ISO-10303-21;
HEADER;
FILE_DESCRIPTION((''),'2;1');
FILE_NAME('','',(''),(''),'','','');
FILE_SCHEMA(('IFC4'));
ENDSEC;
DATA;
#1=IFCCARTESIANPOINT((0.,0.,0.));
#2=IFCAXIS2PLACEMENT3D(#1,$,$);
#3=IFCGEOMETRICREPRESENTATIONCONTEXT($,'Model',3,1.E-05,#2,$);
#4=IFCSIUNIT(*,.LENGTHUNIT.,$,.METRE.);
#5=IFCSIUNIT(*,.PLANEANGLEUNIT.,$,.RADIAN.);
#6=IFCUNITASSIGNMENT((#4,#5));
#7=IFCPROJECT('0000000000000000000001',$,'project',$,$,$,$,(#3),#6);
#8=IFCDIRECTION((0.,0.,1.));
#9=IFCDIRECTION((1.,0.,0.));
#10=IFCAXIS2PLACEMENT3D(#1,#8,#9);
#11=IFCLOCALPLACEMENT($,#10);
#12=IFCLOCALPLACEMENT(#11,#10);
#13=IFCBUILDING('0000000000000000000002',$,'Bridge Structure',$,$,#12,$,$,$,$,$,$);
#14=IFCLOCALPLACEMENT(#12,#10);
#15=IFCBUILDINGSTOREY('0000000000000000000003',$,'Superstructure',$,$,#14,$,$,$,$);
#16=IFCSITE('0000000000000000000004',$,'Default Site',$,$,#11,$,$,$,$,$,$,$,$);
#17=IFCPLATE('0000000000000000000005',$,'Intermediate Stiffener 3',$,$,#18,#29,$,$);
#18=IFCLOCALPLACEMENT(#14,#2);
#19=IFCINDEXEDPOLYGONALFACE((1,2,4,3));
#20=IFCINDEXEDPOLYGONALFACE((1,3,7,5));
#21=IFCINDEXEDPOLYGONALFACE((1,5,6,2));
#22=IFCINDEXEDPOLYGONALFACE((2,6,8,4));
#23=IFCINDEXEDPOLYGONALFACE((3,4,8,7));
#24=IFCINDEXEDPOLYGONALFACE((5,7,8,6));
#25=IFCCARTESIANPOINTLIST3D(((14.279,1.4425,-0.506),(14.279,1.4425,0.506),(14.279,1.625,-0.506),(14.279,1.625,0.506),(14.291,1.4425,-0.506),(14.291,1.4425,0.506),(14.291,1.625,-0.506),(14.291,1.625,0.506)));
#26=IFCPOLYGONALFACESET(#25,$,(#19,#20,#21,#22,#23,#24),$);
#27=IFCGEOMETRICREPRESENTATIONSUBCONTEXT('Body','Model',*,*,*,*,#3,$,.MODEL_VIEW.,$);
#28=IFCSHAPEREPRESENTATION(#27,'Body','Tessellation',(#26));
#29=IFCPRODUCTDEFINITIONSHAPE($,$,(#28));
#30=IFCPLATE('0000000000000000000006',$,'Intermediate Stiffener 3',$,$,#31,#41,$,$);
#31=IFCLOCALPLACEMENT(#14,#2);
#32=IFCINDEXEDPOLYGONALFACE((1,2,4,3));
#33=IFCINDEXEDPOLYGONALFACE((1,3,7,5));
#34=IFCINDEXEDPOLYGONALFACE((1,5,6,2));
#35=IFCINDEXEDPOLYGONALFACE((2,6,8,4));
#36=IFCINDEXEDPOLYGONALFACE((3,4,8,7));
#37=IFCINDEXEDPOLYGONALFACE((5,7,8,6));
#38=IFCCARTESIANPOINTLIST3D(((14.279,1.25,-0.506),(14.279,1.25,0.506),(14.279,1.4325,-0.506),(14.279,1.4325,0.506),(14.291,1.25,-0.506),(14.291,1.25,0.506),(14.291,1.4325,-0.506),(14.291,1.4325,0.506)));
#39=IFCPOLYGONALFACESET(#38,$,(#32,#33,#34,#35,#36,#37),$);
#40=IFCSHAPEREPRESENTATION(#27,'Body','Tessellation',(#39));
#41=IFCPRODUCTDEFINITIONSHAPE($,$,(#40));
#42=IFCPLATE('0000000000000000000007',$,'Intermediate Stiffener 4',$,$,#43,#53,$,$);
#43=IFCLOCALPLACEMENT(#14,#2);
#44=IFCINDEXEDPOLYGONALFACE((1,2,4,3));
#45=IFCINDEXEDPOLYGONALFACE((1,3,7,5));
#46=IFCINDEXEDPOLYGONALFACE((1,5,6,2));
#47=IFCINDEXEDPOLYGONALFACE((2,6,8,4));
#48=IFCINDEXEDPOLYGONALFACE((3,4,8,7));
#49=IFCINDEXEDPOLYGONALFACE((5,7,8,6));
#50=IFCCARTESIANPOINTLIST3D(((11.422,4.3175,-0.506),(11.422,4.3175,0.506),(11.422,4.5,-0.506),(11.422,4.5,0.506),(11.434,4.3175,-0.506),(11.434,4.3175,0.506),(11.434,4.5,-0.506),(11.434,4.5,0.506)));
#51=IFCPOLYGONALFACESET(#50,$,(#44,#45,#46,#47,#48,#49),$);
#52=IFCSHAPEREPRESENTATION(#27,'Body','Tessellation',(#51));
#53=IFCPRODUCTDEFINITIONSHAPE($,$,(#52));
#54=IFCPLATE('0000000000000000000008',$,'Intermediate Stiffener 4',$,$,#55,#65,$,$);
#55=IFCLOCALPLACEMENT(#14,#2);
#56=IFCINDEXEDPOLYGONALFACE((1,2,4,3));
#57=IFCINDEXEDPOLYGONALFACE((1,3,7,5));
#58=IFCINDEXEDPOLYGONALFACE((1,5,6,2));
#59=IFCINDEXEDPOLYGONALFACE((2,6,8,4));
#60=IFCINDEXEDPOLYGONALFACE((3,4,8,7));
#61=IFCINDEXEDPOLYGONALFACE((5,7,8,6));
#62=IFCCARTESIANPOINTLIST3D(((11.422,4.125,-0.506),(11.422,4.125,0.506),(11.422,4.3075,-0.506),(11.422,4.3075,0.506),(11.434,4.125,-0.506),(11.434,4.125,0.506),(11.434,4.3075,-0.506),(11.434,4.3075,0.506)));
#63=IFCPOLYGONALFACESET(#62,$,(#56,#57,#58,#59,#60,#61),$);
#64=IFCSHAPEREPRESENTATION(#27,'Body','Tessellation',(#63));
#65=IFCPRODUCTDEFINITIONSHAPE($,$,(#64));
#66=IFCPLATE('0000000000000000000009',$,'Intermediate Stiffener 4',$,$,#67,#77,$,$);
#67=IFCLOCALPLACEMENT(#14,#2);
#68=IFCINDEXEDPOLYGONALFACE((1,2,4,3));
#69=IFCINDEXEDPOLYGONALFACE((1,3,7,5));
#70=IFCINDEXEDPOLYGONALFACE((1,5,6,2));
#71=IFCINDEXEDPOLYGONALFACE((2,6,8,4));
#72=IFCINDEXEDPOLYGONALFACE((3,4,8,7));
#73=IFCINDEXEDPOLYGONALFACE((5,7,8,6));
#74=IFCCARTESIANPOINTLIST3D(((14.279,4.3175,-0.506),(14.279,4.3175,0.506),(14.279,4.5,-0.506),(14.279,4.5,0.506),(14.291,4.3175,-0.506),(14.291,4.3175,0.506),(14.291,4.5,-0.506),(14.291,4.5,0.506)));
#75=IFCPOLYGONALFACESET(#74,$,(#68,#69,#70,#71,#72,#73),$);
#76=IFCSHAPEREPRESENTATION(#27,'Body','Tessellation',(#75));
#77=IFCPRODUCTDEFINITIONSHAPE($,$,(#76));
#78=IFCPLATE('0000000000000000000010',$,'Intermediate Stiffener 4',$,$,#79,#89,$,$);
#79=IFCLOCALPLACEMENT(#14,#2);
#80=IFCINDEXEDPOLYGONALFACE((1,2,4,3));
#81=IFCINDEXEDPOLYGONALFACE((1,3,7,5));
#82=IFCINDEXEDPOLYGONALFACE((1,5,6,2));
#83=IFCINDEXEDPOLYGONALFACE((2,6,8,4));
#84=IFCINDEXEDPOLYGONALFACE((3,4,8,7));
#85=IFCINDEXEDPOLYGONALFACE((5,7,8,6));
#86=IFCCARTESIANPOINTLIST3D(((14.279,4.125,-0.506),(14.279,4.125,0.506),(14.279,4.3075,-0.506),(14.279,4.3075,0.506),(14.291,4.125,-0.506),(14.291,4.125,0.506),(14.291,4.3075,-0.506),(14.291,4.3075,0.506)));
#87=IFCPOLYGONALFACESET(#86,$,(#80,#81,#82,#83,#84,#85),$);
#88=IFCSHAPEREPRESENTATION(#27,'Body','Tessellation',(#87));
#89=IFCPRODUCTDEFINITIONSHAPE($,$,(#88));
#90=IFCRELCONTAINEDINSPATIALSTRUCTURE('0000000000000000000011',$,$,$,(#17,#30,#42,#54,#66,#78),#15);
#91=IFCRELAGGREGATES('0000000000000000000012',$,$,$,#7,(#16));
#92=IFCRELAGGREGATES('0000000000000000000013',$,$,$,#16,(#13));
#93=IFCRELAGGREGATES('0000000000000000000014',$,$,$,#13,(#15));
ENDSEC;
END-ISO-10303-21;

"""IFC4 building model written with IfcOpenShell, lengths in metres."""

from ifc_helpers import new_model, si_unit, frame, origin, origin_with_axes, origin_2d_with_axis, place, context, subcontext, project, spatial, rectangle, extrude, element, save


model = new_model("IFC4")

# Units and contexts
model_context = context("Model", 3, precision=1e-05, world=origin())
body_context = subcontext(model_context, "Body", "Model", "MODEL_VIEW")
ifc_project = project(units=[si_unit("LENGTHUNIT", "METRE"), si_unit("PLANEANGLEUNIT", "RADIAN")], contexts=[model_context])

# Site, building, storey
site_placement = place(None, origin_with_axes())
site = spatial("IfcSite", under=ifc_project, at=site_placement, Name="Default Site")
building_placement = place(site_placement, origin_with_axes())
building = spatial("IfcBuilding", under=site, at=building_placement, Name="Bridge Structure")
storey_placement = place(building_placement, origin_with_axes())
storey = spatial("IfcBuildingStorey", under=building, at=storey_placement, Name="Superstructure")

# Plates
for number, where, z_axis, x_axis, name in (
    (1, (14.285, 1.5337, -0.506), (0.0, 0.0, 1.0), (1.0, 0.0, 0.0), "Intermediate Stiffener 3"),
    (2, (14.285, 1.3413, -0.506), (0.0, 0.0, 1.0), (1.0, 0.0, 0.0), "Intermediate Stiffener 3"),
    (3, (11.428, 4.4088, -0.506), (0.0, 0.0, 1.0), (1.0, 0.0, 0.0), "Intermediate Stiffener 4"),
    (4, (11.428, 4.2163, -0.506), (0.0, 0.0, 1.0), (1.0, 0.0, 0.0), "Intermediate Stiffener 4"),
    (5, (14.285, 4.4088, -0.506), (0.0, 0.0, 1.0), (1.0, 0.0, 0.0), "Intermediate Stiffener 4"),
    (6, (14.285, 4.2163, -0.506), (0.0, 0.0, 1.0), (1.0, 0.0, 0.0), "Intermediate Stiffener 4"),
):
    element("IfcPlate", number, at=place(storey_placement, frame(where, z_axis=z_axis, x_axis=x_axis)), inside=storey, Name=name, context=body_context, shape_type="SweptSolid", body=[
        extrude(rectangle(XDim=0.012, YDim=0.1825, at=origin_2d_with_axis()), origin_with_axes(), (0.0, 0.0, 1.0), 1.012),
    ])

save(model, "model.ifc")
